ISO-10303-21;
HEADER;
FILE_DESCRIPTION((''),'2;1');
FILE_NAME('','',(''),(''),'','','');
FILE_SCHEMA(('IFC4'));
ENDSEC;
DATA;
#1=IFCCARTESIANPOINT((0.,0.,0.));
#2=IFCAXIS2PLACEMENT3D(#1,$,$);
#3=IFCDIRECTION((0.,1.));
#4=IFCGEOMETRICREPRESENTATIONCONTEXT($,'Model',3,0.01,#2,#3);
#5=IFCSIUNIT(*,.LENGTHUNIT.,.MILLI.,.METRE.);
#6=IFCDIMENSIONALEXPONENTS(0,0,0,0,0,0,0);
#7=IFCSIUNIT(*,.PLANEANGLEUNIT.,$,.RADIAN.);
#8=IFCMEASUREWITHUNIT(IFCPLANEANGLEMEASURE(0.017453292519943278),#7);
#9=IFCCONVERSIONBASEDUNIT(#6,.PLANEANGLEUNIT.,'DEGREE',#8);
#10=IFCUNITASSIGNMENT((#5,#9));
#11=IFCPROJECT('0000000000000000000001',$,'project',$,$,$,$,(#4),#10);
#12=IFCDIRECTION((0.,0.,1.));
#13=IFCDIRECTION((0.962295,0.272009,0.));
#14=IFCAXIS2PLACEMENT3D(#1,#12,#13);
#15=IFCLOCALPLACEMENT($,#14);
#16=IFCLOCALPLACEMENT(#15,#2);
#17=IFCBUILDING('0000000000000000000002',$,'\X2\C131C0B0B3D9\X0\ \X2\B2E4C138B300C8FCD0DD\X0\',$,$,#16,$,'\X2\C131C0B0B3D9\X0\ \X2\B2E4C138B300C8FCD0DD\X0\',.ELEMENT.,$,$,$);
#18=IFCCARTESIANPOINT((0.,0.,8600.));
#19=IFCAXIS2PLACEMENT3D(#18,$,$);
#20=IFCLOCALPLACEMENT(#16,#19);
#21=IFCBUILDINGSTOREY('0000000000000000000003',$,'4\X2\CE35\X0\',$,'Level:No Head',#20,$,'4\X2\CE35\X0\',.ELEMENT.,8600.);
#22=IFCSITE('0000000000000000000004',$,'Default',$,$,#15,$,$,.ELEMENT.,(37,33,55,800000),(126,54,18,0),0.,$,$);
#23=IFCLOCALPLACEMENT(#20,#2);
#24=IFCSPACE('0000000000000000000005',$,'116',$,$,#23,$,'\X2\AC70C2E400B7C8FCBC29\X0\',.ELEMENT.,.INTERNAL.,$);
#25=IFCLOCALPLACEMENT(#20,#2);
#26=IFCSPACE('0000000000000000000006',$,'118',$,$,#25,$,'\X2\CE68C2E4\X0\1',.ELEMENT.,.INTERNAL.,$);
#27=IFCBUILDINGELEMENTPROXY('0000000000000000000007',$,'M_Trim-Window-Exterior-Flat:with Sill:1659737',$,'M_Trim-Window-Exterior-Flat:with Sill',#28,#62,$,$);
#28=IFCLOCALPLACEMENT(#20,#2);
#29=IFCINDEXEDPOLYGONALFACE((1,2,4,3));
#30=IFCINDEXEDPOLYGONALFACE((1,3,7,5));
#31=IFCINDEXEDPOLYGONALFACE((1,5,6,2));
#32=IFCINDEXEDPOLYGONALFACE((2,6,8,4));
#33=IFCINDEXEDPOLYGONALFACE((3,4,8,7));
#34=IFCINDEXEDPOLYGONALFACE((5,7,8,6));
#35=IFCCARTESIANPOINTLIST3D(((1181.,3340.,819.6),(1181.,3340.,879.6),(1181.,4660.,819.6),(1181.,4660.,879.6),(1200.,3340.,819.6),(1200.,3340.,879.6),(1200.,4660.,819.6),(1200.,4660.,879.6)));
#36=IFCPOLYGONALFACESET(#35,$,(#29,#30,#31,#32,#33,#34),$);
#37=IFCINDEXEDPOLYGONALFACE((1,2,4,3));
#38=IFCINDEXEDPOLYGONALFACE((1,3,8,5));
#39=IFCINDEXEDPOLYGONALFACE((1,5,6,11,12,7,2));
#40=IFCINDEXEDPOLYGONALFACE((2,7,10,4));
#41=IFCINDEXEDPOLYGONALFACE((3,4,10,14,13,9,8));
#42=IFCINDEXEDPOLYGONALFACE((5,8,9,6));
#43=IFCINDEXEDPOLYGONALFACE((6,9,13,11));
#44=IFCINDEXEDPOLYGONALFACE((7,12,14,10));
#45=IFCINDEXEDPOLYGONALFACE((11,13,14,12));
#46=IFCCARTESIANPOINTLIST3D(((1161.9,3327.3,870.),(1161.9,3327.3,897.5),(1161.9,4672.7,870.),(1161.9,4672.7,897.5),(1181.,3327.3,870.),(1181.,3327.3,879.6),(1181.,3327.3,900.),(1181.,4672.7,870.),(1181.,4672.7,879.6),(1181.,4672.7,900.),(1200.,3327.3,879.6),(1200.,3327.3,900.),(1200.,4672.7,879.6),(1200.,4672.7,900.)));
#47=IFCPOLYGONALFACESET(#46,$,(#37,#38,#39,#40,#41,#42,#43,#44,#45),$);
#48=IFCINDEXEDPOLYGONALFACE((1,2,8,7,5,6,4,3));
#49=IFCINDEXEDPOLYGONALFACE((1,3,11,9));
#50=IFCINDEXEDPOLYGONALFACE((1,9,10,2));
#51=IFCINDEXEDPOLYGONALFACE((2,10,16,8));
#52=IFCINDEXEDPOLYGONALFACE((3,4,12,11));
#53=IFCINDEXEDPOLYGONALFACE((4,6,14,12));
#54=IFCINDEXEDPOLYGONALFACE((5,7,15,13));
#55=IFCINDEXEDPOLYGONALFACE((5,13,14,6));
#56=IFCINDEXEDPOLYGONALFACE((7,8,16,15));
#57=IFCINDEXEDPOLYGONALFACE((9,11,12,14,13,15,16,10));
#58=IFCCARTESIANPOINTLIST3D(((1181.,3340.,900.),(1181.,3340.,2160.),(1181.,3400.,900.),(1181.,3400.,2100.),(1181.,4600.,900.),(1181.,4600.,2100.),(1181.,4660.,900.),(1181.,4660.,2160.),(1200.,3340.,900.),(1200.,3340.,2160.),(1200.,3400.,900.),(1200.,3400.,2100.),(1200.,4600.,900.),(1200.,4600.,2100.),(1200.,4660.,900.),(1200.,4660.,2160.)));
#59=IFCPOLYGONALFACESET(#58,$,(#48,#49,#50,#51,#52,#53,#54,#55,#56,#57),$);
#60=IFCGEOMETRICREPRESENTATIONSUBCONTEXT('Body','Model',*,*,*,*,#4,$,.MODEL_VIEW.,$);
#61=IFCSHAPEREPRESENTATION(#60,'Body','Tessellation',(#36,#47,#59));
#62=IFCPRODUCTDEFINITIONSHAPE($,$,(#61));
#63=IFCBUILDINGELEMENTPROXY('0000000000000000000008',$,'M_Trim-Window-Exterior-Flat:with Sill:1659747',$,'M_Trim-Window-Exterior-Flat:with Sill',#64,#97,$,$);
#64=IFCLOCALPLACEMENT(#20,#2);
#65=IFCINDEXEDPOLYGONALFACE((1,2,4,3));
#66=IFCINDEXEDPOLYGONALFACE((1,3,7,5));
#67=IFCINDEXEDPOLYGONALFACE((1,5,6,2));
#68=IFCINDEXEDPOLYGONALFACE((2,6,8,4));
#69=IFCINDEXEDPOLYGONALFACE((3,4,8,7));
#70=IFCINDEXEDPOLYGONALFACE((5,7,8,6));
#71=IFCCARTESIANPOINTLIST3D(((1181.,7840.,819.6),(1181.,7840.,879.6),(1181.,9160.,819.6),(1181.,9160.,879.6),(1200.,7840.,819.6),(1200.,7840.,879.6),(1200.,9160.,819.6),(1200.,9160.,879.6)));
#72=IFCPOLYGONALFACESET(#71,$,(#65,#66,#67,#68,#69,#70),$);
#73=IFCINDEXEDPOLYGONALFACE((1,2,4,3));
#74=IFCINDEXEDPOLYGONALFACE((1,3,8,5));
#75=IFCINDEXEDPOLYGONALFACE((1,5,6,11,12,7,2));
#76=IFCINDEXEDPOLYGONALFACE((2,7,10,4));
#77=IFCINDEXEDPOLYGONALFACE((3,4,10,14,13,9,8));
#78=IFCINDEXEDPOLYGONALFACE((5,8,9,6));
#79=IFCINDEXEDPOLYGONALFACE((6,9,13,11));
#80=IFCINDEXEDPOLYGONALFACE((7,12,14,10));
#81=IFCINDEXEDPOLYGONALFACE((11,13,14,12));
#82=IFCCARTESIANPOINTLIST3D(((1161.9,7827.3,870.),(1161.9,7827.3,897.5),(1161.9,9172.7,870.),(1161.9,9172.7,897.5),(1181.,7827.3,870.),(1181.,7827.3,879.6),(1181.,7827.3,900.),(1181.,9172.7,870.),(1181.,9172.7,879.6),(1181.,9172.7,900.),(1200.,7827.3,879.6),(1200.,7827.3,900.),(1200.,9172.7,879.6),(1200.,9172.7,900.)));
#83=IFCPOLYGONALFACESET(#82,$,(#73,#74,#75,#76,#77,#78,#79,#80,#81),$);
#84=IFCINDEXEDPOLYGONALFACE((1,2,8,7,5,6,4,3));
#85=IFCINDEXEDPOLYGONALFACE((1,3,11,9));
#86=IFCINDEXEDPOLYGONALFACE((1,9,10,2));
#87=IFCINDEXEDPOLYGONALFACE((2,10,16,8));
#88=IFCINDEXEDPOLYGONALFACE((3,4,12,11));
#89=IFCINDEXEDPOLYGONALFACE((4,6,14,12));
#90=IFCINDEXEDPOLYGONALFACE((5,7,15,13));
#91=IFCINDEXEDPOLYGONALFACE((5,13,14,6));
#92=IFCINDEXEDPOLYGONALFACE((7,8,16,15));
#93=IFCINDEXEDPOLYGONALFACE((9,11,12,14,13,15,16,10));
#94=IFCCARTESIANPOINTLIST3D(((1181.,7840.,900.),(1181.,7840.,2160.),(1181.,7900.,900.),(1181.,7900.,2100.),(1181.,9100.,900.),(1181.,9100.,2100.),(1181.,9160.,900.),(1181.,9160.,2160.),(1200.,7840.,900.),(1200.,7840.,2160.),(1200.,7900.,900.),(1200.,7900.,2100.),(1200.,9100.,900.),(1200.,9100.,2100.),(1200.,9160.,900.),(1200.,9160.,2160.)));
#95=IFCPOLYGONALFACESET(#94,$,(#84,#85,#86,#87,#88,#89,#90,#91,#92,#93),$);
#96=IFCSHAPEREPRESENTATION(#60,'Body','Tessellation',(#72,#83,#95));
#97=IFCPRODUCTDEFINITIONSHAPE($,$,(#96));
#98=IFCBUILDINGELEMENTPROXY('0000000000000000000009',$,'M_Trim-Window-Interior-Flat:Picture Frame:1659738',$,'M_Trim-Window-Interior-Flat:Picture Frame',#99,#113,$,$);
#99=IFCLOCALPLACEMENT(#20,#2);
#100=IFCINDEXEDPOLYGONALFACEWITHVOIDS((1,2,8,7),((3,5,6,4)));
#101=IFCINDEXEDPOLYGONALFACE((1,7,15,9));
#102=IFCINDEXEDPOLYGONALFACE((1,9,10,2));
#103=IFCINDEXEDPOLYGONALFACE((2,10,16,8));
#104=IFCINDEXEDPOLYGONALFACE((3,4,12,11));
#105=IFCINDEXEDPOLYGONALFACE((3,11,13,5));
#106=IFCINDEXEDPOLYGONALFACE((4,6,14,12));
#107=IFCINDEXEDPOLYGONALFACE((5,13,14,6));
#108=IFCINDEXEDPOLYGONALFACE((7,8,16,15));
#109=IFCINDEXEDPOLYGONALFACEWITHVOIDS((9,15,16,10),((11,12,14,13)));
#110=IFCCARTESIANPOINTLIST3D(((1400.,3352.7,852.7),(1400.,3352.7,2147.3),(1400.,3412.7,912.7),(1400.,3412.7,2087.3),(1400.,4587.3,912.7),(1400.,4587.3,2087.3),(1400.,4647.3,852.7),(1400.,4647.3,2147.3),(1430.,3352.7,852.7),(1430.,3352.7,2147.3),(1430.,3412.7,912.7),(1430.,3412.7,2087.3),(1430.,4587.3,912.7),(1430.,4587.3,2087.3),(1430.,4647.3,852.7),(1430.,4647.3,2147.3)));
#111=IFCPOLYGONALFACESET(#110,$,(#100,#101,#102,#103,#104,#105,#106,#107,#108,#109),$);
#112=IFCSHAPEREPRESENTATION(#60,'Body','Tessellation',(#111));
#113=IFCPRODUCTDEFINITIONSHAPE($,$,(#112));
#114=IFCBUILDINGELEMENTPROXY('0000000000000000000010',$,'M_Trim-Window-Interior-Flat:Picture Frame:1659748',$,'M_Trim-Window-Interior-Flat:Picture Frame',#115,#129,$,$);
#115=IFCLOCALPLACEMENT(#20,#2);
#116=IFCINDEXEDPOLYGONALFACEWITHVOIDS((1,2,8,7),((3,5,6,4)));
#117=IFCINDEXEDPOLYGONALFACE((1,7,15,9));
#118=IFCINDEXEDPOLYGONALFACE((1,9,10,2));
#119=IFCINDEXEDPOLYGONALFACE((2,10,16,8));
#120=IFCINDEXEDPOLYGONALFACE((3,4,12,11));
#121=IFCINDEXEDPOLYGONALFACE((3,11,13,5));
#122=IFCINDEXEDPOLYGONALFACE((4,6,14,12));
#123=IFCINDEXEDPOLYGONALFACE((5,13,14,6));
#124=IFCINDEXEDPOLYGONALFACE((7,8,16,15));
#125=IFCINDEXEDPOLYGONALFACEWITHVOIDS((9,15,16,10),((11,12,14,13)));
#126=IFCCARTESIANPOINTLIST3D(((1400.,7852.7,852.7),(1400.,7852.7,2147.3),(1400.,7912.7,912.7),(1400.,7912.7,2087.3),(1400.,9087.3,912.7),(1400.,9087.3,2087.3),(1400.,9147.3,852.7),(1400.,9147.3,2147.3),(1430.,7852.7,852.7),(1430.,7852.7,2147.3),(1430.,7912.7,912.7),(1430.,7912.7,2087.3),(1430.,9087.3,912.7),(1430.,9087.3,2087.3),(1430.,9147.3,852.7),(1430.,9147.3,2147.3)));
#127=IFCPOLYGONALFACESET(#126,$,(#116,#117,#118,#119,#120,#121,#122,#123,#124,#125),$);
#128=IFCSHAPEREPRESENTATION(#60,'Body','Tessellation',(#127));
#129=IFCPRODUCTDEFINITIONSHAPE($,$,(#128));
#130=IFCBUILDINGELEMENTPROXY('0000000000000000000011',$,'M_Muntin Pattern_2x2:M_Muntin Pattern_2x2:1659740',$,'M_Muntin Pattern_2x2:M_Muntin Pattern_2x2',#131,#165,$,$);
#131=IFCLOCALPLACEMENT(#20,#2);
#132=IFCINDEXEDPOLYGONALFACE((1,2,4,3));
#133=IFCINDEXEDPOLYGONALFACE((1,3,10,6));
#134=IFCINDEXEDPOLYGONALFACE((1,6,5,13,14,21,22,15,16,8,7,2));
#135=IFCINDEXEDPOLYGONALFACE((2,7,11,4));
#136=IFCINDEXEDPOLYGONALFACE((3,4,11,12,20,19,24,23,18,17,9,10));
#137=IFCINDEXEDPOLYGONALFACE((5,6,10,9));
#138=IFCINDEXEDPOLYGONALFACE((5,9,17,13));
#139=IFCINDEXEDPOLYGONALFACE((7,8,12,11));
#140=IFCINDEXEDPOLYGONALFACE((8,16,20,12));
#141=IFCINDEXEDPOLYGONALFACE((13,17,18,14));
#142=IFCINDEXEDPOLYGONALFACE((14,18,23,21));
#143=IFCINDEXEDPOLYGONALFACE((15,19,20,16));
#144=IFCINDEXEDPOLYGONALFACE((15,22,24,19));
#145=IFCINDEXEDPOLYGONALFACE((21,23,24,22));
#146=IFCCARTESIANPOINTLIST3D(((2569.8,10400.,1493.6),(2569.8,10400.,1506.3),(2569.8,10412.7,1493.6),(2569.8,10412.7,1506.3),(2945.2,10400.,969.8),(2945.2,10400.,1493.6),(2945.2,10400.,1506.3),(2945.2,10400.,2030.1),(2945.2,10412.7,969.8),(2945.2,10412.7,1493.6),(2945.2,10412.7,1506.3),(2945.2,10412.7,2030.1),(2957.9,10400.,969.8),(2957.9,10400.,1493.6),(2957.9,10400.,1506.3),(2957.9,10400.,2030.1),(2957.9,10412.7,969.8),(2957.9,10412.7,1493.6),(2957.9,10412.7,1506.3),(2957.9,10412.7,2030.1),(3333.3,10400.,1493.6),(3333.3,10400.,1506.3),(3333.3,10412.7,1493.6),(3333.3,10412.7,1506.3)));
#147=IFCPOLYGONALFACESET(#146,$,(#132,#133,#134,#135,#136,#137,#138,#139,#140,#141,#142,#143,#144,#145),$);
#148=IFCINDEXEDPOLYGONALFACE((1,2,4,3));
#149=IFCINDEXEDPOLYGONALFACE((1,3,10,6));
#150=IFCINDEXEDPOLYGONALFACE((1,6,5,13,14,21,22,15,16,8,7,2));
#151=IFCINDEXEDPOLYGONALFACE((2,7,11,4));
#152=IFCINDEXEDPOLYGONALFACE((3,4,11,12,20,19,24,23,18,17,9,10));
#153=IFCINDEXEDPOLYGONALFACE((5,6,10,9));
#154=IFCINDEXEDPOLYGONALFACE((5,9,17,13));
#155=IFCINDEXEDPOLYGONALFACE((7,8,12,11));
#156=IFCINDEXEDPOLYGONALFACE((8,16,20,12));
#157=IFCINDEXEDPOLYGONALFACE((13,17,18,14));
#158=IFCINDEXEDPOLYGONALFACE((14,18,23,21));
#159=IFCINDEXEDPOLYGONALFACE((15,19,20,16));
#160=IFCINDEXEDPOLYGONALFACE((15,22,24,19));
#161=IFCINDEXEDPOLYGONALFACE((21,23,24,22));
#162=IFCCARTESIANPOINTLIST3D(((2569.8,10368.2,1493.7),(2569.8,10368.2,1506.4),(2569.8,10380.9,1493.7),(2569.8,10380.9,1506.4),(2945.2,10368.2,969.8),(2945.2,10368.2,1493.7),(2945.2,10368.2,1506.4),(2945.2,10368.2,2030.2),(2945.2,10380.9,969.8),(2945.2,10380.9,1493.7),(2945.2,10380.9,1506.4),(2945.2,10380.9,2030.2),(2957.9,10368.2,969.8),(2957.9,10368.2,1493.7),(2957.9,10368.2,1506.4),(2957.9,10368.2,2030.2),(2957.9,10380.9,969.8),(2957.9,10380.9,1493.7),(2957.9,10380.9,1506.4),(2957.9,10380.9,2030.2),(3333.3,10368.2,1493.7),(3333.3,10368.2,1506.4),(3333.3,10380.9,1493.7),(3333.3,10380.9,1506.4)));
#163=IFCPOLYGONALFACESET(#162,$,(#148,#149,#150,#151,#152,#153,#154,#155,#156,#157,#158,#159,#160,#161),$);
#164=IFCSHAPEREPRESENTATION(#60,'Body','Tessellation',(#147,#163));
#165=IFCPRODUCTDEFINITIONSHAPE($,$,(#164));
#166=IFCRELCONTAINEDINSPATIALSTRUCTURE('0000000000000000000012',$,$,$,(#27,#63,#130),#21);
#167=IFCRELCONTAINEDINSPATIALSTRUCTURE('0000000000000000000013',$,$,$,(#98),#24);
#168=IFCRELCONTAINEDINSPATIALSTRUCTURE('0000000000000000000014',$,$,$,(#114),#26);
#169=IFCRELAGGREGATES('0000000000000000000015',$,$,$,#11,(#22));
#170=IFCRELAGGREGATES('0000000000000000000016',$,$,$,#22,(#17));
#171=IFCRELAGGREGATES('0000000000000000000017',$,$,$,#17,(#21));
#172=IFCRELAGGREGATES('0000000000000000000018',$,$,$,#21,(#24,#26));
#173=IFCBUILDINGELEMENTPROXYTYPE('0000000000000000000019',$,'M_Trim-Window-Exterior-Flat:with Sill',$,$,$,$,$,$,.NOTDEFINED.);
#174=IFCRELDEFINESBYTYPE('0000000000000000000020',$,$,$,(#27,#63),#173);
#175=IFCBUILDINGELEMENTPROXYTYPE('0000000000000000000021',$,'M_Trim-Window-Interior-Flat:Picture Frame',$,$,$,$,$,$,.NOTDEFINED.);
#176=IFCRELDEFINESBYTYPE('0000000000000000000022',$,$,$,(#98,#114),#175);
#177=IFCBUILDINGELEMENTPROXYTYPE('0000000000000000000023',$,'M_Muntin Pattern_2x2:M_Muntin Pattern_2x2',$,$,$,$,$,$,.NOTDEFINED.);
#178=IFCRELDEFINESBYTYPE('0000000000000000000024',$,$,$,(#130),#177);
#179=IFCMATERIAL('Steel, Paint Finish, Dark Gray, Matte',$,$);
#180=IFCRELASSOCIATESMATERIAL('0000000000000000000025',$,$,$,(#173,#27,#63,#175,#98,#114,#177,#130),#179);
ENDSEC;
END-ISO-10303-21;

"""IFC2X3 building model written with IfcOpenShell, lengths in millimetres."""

from ifc_helpers import new_model, entity, si_unit, converted_unit, direction, frame, frame_2d, origin, place, context, subcontext, project, spatial, polyline, rectangle, outline, extrude, source, transform, mapped, material, type_object, type_shapes, element, save


model = new_model("IFC2X3")

# Units and contexts
model_context = context("Model", 3, precision=0.01, world=origin(), true_north=direction((0.0, 1.0)))
body_context = subcontext(model_context, "Body", "Model", "MODEL_VIEW")
ifc_project = project(units=[si_unit("LENGTHUNIT", "METRE", prefix="MILLI"), converted_unit("PLANEANGLEUNIT", "DEGREE", entity("IfcPlaneAngleMeasure", 0.017453292519943278), si_unit("PLANEANGLEUNIT", "RADIAN"), dimensions=[0, 0, 0, 0, 0, 0, 0])], contexts=[model_context])

# Site, building, storey
site_placement = place(None, frame((0.0, 0.0, 0.0), z_axis=(0.0, 0.0, 1.0), x_axis=(0.962295, 0.272009, 0.0)))
site = spatial("IfcSite", under=ifc_project, at=site_placement, Name="Default", CompositionType="ELEMENT", RefLatitude=(37, 33, 55, 800000), RefLongitude=(126, 54, 18, 0), RefElevation=0.0)
building_placement = place(site_placement, origin())
building = spatial("IfcBuilding", under=site, at=building_placement, Name="성산동 다세대주택", LongName="성산동 다세대주택", CompositionType="ELEMENT")
storey_placement = place(building_placement, frame((0.0, 0.0, 8600.0)))
storey = spatial("IfcBuildingStorey", under=building, at=storey_placement, Name="4층", ObjectType="Level:No Head", LongName="4층", CompositionType="ELEMENT", Elevation=8600.0)

# Shared definitions
space_1_placement = place(storey_placement, origin())
space_1 = spatial("IfcSpace", under=storey, at=space_1_placement, Name="116", LongName="거실·주방", CompositionType="ELEMENT", InteriorOrExteriorSpace="INTERNAL")

# Shared definitions
space_2_placement = place(storey_placement, origin())
space_2 = spatial("IfcSpace", under=storey, at=space_2_placement, Name="118", LongName="침실1", CompositionType="ELEMENT", InteriorOrExteriorSpace="INTERNAL")

# Building element proxies
ifc_material_1 = material(Name="Steel, Paint Finish, Dark Gray, Matte")
building_element_proxy_type_1 = type_object("IfcBuildingElementProxyType", Name="M_Trim-Window-Exterior-Flat:with Sill", PredefinedType="NOTDEFINED", material=ifc_material_1)
shared_shape_1 = source(origin(), body_context, "Body", "SweptSolid", [
    extrude(rectangle(XDim=1320.0, YDim=60.0, at=frame_2d((0.0, 0.0), x_axis=(1.0, 0.0))), frame((0.0, -1250.4, 0.0), z_axis=(0.0, 0.0, 1.0), x_axis=(-1.0, 0.0, 0.0)), (0.0, 0.0, 1.0), 19.0),
    extrude(outline(polyline([(-19.0, -15.2), (0.0, -15.2), (0.0, -5.7), (19.0, -5.7), (19.0, 14.8), (0.0, 14.8), (-19.0, 12.3), (-19.0, -15.2)])), frame((-672.7, -1214.8, 19.0), z_axis=(1.0, 0.0, 0.0), x_axis=(0.0, 0.0, -1.0)), (0.0, 0.0, 1.0), 1345.4),
    extrude(outline(polyline([(-645.0, -660.0), (615.0, -660.0), (615.0, -600.0), (-585.0, -600.0), (-585.0, 600.0), (615.0, 600.0), (615.0, 660.0), (-645.0, 660.0), (-645.0, -660.0)])), frame((0.0, -585.0, 0.0), z_axis=(0.0, 0.0, 1.0), x_axis=(0.0, -1.0, 0.0)), (0.0, 0.0, 1.0), 19.0),
])
type_shapes(building_element_proxy_type_1, [shared_shape_1])
for number, where, z_axis, x_axis, name in (
    (1, (1200.0, 4000.0, 2100.0), (-1.0, 0.0, 0.0), (0.0, -1.0, 0.0), "M_Trim-Window-Exterior-Flat:with Sill:1659737"),
    (2, (1200.0, 8500.0, 2100.0), (-1.0, 0.0, 0.0), (0.0, -1.0, 0.0), "M_Trim-Window-Exterior-Flat:with Sill:1659747"),
):
    element("IfcBuildingElementProxy", number, at=place(storey_placement, frame(where, z_axis=z_axis, x_axis=x_axis)), inside=storey, type_object=building_element_proxy_type_1, material=ifc_material_1, Name=name, ObjectType="M_Trim-Window-Exterior-Flat:with Sill", context=body_context, shape_type="MappedRepresentation", body=[
        mapped(shared_shape_1, transform((0.0, 0.0, 0.0), scale=1.0)),
    ])
building_element_proxy_type_2 = type_object("IfcBuildingElementProxyType", Name="M_Trim-Window-Interior-Flat:Picture Frame", PredefinedType="NOTDEFINED", material=ifc_material_1)
shared_shape_2 = source(origin(), body_context, "Body", "SweptSolid", [
    extrude(outline(polyline([(-647.3, -647.3), (647.3, -647.3), (647.3, 647.3), (-647.3, 647.3), (-647.3, -647.3)]), holes=[polyline([(-587.3, -587.3), (-587.3, 587.3), (587.3, 587.3), (587.3, -587.3), (-587.3, -587.3)])]), frame((0.0, -600.0, 0.0), z_axis=(0.0, 0.0, 1.0), x_axis=(-1.0, 0.0, 0.0)), (0.0, 0.0, 1.0), 30.0),
])
type_shapes(building_element_proxy_type_2, [shared_shape_2])
proxy_1_placement = place(space_1_placement, frame((1400.0, 4000.0, 2100.0), z_axis=(1.0, 0.0, 0.0), x_axis=(0.0, 1.0, 0.0)))
element("IfcBuildingElementProxy", 3, at=proxy_1_placement, inside=space_1, type_object=building_element_proxy_type_2, material=ifc_material_1, Name="M_Trim-Window-Interior-Flat:Picture Frame:1659738", ObjectType="M_Trim-Window-Interior-Flat:Picture Frame", context=body_context, shape_type="MappedRepresentation", body=[
    mapped(shared_shape_2, transform((0.0, 0.0, 0.0), scale=1.0)),
])
proxy_2_placement = place(space_2_placement, frame((1400.0, 8500.0, 2100.0), z_axis=(1.0, 0.0, 0.0), x_axis=(0.0, 1.0, 0.0)))
element("IfcBuildingElementProxy", 4, at=proxy_2_placement, inside=space_2, type_object=building_element_proxy_type_2, material=ifc_material_1, Name="M_Trim-Window-Interior-Flat:Picture Frame:1659748", ObjectType="M_Trim-Window-Interior-Flat:Picture Frame", context=body_context, shape_type="MappedRepresentation", body=[
    mapped(shared_shape_2, transform((0.0, 0.0, 0.0), scale=1.0)),
])
building_element_proxy_type_3 = type_object("IfcBuildingElementProxyType", Name="M_Muntin Pattern_2x2:M_Muntin Pattern_2x2", PredefinedType="NOTDEFINED", material=ifc_material_1)
shared_shape_3 = source(origin(), body_context, "Body", "SweptSolid", [
    extrude(outline(polyline([(6.4, -6.4), (530.1, -6.4), (530.1, 6.3), (6.4, 6.3), (6.4, 381.7), (-6.3, 381.7), (-6.3, 6.3), (-530.2, 6.3), (-530.2, -6.4), (-6.3, -6.4), (-6.3, -381.7), (6.4, -381.7), (6.4, -6.4)])), frame((0.0, 9.5, 530.1), z_axis=(0.0, 1.0, 0.0), x_axis=(0.0, 0.0, 1.0)), (0.0, 0.0, 1.0), 12.7),
    extrude(outline(polyline([(6.4, -6.4), (530.2, -6.4), (530.2, 6.3), (6.4, 6.3), (6.4, 381.7), (-6.3, 381.7), (-6.3, 6.3), (-530.2, 6.3), (-530.2, -6.4), (-6.3, -6.4), (-6.3, -381.7), (6.4, -381.7), (6.4, -6.4)])), frame((0.0, -22.2, 530.2), z_axis=(0.0, 1.0, 0.0), x_axis=(0.0, 0.0, 1.0)), (0.0, 0.0, 1.0), 12.7),
])
type_shapes(building_element_proxy_type_3, [shared_shape_3])
proxy_3_placement = place(storey_placement, frame((2951.6, 10390.5, 969.8)))
element("IfcBuildingElementProxy", 5, at=proxy_3_placement, inside=storey, type_object=building_element_proxy_type_3, material=ifc_material_1, Name="M_Muntin Pattern_2x2:M_Muntin Pattern_2x2:1659740", ObjectType="M_Muntin Pattern_2x2:M_Muntin Pattern_2x2", context=body_context, shape_type="MappedRepresentation", body=[
    mapped(shared_shape_3, transform((0.0, 0.0, 0.0), scale=1.0)),
])

save(model, "model.ifc")
